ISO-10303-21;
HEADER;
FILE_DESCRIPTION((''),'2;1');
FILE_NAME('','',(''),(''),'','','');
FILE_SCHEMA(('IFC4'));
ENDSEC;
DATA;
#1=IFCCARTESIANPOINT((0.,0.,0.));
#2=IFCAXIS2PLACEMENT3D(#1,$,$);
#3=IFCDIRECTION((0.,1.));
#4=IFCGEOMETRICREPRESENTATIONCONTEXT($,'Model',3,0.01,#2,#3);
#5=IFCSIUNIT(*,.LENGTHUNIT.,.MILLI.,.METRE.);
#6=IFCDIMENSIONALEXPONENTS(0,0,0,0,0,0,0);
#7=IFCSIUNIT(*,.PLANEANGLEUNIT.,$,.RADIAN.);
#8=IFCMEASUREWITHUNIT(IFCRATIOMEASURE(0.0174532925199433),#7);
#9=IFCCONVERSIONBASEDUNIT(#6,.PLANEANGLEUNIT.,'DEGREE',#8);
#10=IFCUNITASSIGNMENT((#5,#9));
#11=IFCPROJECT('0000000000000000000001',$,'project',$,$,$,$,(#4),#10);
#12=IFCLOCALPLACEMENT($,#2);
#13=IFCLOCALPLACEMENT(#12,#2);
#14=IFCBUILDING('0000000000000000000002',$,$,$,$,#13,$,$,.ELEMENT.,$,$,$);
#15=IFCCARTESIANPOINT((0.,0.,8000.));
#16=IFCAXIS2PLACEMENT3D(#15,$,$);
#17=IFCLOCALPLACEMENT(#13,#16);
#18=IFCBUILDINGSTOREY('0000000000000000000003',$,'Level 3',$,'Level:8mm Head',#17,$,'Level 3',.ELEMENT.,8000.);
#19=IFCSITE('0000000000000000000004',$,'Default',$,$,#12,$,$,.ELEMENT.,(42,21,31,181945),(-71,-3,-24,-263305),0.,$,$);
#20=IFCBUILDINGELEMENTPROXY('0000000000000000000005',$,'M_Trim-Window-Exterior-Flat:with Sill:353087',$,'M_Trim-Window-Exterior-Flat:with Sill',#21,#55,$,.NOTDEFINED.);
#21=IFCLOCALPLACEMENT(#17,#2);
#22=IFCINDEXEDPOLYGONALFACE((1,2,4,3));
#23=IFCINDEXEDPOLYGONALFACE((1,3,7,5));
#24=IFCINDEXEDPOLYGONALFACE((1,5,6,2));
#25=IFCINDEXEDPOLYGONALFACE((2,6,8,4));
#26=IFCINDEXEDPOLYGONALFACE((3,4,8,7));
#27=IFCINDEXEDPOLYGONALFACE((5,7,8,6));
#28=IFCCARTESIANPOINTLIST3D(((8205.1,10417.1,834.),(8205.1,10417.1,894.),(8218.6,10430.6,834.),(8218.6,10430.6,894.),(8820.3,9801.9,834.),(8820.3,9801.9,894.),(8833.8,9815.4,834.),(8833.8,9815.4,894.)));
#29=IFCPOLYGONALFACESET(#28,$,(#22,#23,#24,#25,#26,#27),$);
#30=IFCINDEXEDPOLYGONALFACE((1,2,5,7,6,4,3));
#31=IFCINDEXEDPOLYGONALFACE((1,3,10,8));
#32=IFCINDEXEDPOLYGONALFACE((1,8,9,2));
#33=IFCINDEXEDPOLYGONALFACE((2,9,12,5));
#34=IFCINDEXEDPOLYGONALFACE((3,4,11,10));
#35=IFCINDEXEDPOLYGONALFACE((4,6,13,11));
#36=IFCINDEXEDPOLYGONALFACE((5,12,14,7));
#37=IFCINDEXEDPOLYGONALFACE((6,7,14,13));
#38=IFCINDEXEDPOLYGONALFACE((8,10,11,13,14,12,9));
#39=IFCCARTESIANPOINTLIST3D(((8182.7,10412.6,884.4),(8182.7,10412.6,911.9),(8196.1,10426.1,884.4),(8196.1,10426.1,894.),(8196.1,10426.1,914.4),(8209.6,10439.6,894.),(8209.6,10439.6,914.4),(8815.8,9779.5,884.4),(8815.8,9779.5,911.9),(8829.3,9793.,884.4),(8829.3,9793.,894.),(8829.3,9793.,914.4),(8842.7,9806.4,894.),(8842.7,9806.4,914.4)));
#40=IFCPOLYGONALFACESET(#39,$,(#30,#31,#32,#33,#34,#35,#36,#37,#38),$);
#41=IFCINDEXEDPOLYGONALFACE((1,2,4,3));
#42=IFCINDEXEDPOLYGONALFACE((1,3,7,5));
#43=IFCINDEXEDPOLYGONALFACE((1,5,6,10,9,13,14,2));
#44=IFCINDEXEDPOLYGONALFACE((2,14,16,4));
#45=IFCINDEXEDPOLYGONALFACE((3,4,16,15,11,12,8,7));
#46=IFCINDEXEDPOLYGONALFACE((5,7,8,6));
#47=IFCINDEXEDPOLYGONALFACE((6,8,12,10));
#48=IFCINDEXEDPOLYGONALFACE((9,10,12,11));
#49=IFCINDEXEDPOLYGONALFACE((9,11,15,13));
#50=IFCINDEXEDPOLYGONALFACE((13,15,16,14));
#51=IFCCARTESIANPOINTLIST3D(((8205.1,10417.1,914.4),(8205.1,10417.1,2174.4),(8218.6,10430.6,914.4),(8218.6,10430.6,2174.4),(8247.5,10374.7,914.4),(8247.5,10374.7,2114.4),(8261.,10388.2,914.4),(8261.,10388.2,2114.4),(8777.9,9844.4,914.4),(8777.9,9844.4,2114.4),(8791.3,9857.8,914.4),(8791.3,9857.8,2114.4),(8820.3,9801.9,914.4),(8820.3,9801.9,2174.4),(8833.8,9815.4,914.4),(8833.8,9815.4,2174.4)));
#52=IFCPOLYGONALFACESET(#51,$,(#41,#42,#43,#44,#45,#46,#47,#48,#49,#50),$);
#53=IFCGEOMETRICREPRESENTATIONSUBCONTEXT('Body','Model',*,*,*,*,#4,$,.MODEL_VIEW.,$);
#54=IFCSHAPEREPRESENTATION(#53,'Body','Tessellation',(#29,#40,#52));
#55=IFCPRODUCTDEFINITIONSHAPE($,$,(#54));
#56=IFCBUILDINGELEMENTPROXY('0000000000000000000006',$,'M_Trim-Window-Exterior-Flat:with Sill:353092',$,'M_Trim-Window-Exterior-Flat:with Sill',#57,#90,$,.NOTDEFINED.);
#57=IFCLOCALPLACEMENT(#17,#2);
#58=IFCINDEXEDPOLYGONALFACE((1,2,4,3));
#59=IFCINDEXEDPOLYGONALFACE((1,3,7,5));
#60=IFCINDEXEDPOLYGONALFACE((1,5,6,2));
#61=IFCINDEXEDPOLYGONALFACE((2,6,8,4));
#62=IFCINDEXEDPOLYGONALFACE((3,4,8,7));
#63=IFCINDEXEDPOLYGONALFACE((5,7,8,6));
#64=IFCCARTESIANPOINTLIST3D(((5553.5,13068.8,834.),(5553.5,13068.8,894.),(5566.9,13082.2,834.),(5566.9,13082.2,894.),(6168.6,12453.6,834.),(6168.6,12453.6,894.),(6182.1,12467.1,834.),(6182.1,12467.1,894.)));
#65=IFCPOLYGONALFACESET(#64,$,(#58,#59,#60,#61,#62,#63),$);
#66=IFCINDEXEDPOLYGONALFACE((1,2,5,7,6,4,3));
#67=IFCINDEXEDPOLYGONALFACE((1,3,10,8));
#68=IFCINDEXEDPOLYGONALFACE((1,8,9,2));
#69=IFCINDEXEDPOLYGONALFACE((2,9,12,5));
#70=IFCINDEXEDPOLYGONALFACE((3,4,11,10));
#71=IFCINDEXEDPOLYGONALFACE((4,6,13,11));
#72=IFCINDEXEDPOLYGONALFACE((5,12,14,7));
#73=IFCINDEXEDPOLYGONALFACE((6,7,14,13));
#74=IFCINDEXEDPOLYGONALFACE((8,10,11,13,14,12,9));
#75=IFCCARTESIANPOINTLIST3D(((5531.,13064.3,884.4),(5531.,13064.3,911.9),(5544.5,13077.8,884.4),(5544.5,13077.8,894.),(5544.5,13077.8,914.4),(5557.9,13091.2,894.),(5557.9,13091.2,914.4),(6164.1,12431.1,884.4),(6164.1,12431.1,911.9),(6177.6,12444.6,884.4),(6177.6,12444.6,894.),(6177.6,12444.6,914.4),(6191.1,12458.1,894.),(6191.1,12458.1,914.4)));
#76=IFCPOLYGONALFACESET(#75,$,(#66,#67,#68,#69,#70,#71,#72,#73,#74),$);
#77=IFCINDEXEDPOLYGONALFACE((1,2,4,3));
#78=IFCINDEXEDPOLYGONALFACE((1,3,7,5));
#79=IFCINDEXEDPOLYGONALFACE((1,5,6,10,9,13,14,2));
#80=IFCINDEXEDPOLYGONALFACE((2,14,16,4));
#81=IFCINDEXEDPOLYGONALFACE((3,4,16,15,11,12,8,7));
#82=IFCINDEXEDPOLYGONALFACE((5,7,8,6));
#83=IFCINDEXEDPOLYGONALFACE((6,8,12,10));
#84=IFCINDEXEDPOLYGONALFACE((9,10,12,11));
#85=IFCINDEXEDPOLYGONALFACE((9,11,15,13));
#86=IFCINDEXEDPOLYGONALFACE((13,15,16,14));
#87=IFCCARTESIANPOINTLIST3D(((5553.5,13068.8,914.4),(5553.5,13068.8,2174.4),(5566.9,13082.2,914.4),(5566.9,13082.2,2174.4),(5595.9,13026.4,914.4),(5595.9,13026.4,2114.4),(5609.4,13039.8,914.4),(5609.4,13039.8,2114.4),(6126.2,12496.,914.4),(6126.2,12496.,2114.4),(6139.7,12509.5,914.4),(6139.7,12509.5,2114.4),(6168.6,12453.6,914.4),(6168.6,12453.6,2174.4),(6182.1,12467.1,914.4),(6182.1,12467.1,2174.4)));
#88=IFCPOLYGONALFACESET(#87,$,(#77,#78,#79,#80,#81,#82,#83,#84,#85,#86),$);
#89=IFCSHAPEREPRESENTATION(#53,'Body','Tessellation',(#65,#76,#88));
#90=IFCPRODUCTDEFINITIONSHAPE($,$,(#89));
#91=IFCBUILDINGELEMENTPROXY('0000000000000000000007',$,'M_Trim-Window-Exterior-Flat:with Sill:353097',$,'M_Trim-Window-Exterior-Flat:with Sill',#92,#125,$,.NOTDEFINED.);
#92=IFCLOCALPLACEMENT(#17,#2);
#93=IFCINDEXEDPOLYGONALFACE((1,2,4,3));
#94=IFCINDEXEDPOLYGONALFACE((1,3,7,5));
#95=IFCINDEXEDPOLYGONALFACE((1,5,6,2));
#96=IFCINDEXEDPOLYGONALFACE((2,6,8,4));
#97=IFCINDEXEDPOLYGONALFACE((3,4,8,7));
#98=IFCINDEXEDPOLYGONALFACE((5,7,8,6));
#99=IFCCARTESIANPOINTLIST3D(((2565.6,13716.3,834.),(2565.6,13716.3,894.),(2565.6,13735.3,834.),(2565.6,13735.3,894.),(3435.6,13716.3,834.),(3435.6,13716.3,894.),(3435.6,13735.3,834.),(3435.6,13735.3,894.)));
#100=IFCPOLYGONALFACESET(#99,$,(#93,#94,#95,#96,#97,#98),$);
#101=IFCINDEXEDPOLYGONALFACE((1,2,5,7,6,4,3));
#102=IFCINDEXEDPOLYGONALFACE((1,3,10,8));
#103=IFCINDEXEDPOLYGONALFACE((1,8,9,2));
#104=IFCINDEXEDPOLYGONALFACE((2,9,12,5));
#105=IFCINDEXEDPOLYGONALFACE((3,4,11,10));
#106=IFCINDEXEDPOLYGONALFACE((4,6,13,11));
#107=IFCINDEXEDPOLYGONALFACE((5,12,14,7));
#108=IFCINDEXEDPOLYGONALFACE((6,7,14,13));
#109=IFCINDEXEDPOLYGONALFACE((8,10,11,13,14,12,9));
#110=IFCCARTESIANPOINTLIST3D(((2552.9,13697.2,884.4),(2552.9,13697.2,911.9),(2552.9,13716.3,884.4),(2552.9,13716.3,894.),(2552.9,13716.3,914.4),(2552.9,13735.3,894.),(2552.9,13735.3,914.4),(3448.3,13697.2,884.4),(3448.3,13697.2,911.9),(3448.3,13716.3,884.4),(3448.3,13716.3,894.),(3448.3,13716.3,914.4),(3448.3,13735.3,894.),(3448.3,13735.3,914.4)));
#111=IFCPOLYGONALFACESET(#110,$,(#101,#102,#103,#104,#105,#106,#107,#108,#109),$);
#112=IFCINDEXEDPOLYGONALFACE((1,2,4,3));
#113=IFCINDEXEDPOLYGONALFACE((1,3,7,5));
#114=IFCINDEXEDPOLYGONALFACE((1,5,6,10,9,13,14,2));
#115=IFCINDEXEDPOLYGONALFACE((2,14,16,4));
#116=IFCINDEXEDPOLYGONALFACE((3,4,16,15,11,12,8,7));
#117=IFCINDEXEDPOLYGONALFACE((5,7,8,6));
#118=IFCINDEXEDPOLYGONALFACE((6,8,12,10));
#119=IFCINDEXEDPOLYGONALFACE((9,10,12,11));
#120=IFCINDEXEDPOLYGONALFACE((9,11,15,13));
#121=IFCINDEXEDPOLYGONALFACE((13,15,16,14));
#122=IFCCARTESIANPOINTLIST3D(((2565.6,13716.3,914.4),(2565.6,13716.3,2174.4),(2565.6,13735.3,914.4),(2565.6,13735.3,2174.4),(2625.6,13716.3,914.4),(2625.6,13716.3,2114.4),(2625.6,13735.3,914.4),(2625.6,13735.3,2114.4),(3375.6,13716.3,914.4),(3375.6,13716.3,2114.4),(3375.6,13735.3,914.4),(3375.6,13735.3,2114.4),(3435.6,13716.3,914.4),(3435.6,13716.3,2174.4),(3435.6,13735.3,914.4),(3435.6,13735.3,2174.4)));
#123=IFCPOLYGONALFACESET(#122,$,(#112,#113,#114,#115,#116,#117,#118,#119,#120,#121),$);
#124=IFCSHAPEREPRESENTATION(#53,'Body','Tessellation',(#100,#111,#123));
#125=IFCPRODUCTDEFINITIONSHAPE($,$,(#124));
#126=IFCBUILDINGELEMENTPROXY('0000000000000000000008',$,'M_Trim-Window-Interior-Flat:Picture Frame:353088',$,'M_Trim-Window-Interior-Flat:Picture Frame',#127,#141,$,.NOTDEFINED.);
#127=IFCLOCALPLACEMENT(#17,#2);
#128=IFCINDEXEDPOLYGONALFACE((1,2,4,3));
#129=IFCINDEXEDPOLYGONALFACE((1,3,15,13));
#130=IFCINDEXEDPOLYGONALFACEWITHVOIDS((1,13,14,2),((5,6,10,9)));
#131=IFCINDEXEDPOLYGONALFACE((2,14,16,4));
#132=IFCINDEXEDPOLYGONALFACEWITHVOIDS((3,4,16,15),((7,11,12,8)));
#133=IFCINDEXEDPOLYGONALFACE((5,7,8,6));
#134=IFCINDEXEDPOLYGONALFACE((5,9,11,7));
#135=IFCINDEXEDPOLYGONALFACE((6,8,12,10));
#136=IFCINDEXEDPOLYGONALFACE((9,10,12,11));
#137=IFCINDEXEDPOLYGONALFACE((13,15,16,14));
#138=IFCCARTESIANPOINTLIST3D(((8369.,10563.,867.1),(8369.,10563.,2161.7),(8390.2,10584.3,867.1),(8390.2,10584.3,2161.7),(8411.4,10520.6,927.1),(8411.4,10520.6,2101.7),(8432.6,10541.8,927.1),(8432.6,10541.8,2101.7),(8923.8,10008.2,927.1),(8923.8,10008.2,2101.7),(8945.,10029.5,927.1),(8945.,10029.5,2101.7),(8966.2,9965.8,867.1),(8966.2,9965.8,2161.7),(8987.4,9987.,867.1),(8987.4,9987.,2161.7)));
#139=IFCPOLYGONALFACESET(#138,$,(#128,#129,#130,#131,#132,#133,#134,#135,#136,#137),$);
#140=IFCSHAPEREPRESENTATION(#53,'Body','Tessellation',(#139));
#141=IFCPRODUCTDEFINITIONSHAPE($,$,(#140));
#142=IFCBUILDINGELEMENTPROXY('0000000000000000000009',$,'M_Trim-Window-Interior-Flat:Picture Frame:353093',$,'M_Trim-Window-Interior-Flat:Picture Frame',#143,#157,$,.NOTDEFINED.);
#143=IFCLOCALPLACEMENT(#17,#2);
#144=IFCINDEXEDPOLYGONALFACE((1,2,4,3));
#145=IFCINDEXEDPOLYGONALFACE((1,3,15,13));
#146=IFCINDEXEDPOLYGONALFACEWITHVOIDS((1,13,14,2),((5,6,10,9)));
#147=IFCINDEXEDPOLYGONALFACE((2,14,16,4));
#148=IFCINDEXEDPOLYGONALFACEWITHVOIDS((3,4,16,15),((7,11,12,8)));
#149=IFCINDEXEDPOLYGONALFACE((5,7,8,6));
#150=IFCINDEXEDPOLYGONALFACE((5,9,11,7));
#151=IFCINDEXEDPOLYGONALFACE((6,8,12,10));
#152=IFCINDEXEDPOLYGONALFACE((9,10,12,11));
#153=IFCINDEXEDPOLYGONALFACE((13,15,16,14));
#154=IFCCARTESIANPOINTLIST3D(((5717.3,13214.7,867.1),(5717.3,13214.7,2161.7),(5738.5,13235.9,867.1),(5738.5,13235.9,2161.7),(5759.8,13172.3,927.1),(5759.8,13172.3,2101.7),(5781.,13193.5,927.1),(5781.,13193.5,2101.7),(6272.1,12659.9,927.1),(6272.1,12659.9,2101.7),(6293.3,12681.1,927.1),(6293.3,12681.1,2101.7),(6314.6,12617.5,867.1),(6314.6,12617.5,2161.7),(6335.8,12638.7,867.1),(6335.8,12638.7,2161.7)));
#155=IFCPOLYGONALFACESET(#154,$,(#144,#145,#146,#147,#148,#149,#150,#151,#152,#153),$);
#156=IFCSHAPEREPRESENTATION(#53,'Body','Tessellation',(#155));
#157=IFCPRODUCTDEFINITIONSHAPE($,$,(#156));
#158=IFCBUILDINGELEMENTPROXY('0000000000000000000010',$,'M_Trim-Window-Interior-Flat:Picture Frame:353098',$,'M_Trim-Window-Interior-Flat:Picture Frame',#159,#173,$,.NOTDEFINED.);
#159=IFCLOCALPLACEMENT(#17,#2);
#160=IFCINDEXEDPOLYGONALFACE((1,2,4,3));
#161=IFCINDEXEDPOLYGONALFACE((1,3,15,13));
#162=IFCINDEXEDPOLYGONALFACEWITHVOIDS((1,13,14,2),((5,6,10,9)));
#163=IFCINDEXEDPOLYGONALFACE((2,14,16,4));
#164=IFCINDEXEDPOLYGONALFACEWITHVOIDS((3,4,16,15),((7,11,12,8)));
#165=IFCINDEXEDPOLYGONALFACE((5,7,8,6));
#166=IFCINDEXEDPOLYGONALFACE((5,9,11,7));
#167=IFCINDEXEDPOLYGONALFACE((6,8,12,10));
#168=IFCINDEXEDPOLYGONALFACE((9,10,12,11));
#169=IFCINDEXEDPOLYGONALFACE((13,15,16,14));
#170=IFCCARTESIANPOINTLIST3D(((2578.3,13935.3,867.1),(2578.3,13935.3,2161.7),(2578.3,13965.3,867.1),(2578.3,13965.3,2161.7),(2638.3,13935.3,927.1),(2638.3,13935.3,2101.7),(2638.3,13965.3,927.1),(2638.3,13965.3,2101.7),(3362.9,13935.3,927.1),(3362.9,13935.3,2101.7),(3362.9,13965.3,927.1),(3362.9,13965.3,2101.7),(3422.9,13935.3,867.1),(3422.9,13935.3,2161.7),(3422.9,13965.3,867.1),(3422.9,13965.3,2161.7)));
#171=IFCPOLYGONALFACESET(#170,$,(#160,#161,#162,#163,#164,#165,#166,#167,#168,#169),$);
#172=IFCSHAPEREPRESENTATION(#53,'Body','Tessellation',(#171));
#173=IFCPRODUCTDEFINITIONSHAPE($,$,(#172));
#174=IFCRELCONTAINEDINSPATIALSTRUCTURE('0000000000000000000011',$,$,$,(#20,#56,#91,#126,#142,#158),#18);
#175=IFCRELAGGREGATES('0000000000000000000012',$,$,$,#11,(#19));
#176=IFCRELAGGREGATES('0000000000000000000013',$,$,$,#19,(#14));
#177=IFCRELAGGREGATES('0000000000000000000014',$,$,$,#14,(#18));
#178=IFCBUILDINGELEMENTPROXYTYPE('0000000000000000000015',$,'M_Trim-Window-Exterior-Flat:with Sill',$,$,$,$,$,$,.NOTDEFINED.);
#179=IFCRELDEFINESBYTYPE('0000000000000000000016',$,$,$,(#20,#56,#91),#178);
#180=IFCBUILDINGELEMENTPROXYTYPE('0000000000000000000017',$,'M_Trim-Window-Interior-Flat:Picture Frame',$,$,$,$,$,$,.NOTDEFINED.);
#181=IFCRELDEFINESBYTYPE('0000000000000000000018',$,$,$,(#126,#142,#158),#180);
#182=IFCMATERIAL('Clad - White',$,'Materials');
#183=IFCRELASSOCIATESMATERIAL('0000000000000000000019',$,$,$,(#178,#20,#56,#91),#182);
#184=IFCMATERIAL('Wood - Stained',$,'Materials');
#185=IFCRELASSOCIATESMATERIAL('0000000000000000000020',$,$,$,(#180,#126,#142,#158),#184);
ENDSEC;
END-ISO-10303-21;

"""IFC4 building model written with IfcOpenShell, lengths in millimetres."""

from ifc_helpers import new_model, entity, si_unit, converted_unit, direction, frame, frame_2d, origin, place, context, subcontext, project, spatial, polyline, rectangle, outline, extrude, source, transform, mapped, material, type_object, type_shapes, element, save


model = new_model("IFC4")

# Units and contexts
model_context = context("Model", 3, precision=0.01, world=origin(), true_north=direction((0.0, 1.0)))
body_context = subcontext(model_context, "Body", "Model", "MODEL_VIEW")
ifc_project = project(units=[si_unit("LENGTHUNIT", "METRE", prefix="MILLI"), converted_unit("PLANEANGLEUNIT", "DEGREE", entity("IfcRatioMeasure", 0.0174532925199433), si_unit("PLANEANGLEUNIT", "RADIAN"), dimensions=[0, 0, 0, 0, 0, 0, 0])], contexts=[model_context])

# Site, building, storey
site_placement = place(None, origin())
site = spatial("IfcSite", under=ifc_project, at=site_placement, Name="Default", CompositionType="ELEMENT", RefLatitude=(42, 21, 31, 181945), RefLongitude=(-71, -3, -24, -263305), RefElevation=0.0)
building_placement = place(site_placement, origin())
building = spatial("IfcBuilding", under=site, at=building_placement, CompositionType="ELEMENT")
storey_placement = place(building_placement, frame((0.0, 0.0, 8000.0)))
storey = spatial("IfcBuildingStorey", under=building, at=storey_placement, Name="Level 3", ObjectType="Level:8mm Head", LongName="Level 3", CompositionType="ELEMENT", Elevation=8000.0)

# Shared definitions
ifc_material_1 = material(Name="Wood - Stained", Category="Materials")

# Building element proxies
ifc_material_2 = material(Name="Clad - White", Category="Materials")
building_element_proxy_type_1 = type_object("IfcBuildingElementProxyType", Name="M_Trim-Window-Exterior-Flat:with Sill", PredefinedType="NOTDEFINED", material=ifc_material_2)
shared_shape_1 = source(origin(), body_context, "Body", "SweptSolid", [
    extrude(rectangle(XDim=870.0, YDim=60.0, at=frame_2d((0.0, 0.0), x_axis=(1.0, 0.0))), frame((0.0, -1250.4, 0.0), z_axis=(0.0, 0.0, 1.0), x_axis=(-1.0, 0.0, 0.0)), (0.0, 0.0, 1.0), 19.1),
    extrude(outline(polyline([(-19.0, -15.2), (0.0, -15.2), (0.0, -5.7), (19.0, -5.7), (19.0, 14.8), (0.0, 14.8), (-19.0, 12.3), (-19.0, -15.2)])), frame((-447.7, -1214.8, 19.0), z_axis=(1.0, 0.0, 0.0), x_axis=(0.0, 0.0, -1.0)), (0.0, 0.0, 1.0), 895.4),
    extrude(outline(polyline([(-645.0, -435.0), (615.0, -435.0), (615.0, -375.0), (-585.0, -375.0), (-585.0, 375.0), (615.0, 375.0), (615.0, 435.0), (-645.0, 435.0), (-645.0, -435.0)])), frame((0.0, -585.0, 0.0), z_axis=(0.0, 0.0, 1.0), x_axis=(0.0, -1.0, 0.0)), (0.0, 0.0, 1.0), 19.1),
])
type_shapes(building_element_proxy_type_1, [shared_shape_1])
for number, where, z_axis, x_axis, name in (
    (1, (8526.2, 10123.0, 2114.4), (-0.707107, -0.707107, 0.0), (0.707107, -0.707107, 0.0), "M_Trim-Window-Exterior-Flat:with Sill:353087"),
    (2, (5874.5, 12774.7, 2114.4), (-0.707107, -0.707107, 0.0), (0.707107, -0.707107, 0.0), "M_Trim-Window-Exterior-Flat:with Sill:353092"),
    (3, (3000.6, 13735.3, 2114.4), (0.0, -1.0, 0.0), (1.0, 0.0, 0.0), "M_Trim-Window-Exterior-Flat:with Sill:353097"),
):
    element("IfcBuildingElementProxy", number, at=place(storey_placement, frame(where, z_axis=z_axis, x_axis=x_axis)), inside=storey, type_object=building_element_proxy_type_1, material=ifc_material_2, Name=name, ObjectType="M_Trim-Window-Exterior-Flat:with Sill", PredefinedType="NOTDEFINED", context=body_context, shape_type="MappedRepresentation", body=[
        mapped(shared_shape_1, transform((0.0, 0.0, 0.0), scale=1.0)),
    ])
building_element_proxy_type_2 = type_object("IfcBuildingElementProxyType", Name="M_Trim-Window-Interior-Flat:Picture Frame", PredefinedType="NOTDEFINED", material=ifc_material_1)
shared_shape_2 = source(origin(), body_context, "Body", "SweptSolid", [
    extrude(outline(polyline([(-422.3, -647.3), (422.3, -647.3), (422.3, 647.3), (-422.3, 647.3), (-422.3, -647.3)]), holes=[polyline([(-362.3, -587.3), (-362.3, 587.3), (362.3, 587.3), (362.3, -587.3), (-362.3, -587.3)])]), frame((0.0, -600.0, 0.0), z_axis=(0.0, 0.0, 1.0), x_axis=(-1.0, 0.0, 0.0)), (0.0, 0.0, 1.0), 30.0),
])
type_shapes(building_element_proxy_type_2, [shared_shape_2])
for number, where, z_axis, x_axis, name in (
    (4, (8667.6, 10264.4, 2114.4), (0.707107, 0.707107, 0.0), (-0.707107, 0.707107, 0.0), "M_Trim-Window-Interior-Flat:Picture Frame:353088"),
    (5, (6015.9, 12916.1, 2114.4), (0.707107, 0.707107, 0.0), (-0.707107, 0.707107, 0.0), "M_Trim-Window-Interior-Flat:Picture Frame:353093"),
    (6, (3000.6, 13935.3, 2114.4), (0.0, 1.0, 0.0), (-1.0, 0.0, 0.0), "M_Trim-Window-Interior-Flat:Picture Frame:353098"),
):
    element("IfcBuildingElementProxy", number, at=place(storey_placement, frame(where, z_axis=z_axis, x_axis=x_axis)), inside=storey, type_object=building_element_proxy_type_2, material=ifc_material_1, Name=name, ObjectType="M_Trim-Window-Interior-Flat:Picture Frame", PredefinedType="NOTDEFINED", context=body_context, shape_type="MappedRepresentation", body=[
        mapped(shared_shape_2, transform((0.0, 0.0, 0.0), scale=1.0)),
    ])

save(model, "model.ifc")
